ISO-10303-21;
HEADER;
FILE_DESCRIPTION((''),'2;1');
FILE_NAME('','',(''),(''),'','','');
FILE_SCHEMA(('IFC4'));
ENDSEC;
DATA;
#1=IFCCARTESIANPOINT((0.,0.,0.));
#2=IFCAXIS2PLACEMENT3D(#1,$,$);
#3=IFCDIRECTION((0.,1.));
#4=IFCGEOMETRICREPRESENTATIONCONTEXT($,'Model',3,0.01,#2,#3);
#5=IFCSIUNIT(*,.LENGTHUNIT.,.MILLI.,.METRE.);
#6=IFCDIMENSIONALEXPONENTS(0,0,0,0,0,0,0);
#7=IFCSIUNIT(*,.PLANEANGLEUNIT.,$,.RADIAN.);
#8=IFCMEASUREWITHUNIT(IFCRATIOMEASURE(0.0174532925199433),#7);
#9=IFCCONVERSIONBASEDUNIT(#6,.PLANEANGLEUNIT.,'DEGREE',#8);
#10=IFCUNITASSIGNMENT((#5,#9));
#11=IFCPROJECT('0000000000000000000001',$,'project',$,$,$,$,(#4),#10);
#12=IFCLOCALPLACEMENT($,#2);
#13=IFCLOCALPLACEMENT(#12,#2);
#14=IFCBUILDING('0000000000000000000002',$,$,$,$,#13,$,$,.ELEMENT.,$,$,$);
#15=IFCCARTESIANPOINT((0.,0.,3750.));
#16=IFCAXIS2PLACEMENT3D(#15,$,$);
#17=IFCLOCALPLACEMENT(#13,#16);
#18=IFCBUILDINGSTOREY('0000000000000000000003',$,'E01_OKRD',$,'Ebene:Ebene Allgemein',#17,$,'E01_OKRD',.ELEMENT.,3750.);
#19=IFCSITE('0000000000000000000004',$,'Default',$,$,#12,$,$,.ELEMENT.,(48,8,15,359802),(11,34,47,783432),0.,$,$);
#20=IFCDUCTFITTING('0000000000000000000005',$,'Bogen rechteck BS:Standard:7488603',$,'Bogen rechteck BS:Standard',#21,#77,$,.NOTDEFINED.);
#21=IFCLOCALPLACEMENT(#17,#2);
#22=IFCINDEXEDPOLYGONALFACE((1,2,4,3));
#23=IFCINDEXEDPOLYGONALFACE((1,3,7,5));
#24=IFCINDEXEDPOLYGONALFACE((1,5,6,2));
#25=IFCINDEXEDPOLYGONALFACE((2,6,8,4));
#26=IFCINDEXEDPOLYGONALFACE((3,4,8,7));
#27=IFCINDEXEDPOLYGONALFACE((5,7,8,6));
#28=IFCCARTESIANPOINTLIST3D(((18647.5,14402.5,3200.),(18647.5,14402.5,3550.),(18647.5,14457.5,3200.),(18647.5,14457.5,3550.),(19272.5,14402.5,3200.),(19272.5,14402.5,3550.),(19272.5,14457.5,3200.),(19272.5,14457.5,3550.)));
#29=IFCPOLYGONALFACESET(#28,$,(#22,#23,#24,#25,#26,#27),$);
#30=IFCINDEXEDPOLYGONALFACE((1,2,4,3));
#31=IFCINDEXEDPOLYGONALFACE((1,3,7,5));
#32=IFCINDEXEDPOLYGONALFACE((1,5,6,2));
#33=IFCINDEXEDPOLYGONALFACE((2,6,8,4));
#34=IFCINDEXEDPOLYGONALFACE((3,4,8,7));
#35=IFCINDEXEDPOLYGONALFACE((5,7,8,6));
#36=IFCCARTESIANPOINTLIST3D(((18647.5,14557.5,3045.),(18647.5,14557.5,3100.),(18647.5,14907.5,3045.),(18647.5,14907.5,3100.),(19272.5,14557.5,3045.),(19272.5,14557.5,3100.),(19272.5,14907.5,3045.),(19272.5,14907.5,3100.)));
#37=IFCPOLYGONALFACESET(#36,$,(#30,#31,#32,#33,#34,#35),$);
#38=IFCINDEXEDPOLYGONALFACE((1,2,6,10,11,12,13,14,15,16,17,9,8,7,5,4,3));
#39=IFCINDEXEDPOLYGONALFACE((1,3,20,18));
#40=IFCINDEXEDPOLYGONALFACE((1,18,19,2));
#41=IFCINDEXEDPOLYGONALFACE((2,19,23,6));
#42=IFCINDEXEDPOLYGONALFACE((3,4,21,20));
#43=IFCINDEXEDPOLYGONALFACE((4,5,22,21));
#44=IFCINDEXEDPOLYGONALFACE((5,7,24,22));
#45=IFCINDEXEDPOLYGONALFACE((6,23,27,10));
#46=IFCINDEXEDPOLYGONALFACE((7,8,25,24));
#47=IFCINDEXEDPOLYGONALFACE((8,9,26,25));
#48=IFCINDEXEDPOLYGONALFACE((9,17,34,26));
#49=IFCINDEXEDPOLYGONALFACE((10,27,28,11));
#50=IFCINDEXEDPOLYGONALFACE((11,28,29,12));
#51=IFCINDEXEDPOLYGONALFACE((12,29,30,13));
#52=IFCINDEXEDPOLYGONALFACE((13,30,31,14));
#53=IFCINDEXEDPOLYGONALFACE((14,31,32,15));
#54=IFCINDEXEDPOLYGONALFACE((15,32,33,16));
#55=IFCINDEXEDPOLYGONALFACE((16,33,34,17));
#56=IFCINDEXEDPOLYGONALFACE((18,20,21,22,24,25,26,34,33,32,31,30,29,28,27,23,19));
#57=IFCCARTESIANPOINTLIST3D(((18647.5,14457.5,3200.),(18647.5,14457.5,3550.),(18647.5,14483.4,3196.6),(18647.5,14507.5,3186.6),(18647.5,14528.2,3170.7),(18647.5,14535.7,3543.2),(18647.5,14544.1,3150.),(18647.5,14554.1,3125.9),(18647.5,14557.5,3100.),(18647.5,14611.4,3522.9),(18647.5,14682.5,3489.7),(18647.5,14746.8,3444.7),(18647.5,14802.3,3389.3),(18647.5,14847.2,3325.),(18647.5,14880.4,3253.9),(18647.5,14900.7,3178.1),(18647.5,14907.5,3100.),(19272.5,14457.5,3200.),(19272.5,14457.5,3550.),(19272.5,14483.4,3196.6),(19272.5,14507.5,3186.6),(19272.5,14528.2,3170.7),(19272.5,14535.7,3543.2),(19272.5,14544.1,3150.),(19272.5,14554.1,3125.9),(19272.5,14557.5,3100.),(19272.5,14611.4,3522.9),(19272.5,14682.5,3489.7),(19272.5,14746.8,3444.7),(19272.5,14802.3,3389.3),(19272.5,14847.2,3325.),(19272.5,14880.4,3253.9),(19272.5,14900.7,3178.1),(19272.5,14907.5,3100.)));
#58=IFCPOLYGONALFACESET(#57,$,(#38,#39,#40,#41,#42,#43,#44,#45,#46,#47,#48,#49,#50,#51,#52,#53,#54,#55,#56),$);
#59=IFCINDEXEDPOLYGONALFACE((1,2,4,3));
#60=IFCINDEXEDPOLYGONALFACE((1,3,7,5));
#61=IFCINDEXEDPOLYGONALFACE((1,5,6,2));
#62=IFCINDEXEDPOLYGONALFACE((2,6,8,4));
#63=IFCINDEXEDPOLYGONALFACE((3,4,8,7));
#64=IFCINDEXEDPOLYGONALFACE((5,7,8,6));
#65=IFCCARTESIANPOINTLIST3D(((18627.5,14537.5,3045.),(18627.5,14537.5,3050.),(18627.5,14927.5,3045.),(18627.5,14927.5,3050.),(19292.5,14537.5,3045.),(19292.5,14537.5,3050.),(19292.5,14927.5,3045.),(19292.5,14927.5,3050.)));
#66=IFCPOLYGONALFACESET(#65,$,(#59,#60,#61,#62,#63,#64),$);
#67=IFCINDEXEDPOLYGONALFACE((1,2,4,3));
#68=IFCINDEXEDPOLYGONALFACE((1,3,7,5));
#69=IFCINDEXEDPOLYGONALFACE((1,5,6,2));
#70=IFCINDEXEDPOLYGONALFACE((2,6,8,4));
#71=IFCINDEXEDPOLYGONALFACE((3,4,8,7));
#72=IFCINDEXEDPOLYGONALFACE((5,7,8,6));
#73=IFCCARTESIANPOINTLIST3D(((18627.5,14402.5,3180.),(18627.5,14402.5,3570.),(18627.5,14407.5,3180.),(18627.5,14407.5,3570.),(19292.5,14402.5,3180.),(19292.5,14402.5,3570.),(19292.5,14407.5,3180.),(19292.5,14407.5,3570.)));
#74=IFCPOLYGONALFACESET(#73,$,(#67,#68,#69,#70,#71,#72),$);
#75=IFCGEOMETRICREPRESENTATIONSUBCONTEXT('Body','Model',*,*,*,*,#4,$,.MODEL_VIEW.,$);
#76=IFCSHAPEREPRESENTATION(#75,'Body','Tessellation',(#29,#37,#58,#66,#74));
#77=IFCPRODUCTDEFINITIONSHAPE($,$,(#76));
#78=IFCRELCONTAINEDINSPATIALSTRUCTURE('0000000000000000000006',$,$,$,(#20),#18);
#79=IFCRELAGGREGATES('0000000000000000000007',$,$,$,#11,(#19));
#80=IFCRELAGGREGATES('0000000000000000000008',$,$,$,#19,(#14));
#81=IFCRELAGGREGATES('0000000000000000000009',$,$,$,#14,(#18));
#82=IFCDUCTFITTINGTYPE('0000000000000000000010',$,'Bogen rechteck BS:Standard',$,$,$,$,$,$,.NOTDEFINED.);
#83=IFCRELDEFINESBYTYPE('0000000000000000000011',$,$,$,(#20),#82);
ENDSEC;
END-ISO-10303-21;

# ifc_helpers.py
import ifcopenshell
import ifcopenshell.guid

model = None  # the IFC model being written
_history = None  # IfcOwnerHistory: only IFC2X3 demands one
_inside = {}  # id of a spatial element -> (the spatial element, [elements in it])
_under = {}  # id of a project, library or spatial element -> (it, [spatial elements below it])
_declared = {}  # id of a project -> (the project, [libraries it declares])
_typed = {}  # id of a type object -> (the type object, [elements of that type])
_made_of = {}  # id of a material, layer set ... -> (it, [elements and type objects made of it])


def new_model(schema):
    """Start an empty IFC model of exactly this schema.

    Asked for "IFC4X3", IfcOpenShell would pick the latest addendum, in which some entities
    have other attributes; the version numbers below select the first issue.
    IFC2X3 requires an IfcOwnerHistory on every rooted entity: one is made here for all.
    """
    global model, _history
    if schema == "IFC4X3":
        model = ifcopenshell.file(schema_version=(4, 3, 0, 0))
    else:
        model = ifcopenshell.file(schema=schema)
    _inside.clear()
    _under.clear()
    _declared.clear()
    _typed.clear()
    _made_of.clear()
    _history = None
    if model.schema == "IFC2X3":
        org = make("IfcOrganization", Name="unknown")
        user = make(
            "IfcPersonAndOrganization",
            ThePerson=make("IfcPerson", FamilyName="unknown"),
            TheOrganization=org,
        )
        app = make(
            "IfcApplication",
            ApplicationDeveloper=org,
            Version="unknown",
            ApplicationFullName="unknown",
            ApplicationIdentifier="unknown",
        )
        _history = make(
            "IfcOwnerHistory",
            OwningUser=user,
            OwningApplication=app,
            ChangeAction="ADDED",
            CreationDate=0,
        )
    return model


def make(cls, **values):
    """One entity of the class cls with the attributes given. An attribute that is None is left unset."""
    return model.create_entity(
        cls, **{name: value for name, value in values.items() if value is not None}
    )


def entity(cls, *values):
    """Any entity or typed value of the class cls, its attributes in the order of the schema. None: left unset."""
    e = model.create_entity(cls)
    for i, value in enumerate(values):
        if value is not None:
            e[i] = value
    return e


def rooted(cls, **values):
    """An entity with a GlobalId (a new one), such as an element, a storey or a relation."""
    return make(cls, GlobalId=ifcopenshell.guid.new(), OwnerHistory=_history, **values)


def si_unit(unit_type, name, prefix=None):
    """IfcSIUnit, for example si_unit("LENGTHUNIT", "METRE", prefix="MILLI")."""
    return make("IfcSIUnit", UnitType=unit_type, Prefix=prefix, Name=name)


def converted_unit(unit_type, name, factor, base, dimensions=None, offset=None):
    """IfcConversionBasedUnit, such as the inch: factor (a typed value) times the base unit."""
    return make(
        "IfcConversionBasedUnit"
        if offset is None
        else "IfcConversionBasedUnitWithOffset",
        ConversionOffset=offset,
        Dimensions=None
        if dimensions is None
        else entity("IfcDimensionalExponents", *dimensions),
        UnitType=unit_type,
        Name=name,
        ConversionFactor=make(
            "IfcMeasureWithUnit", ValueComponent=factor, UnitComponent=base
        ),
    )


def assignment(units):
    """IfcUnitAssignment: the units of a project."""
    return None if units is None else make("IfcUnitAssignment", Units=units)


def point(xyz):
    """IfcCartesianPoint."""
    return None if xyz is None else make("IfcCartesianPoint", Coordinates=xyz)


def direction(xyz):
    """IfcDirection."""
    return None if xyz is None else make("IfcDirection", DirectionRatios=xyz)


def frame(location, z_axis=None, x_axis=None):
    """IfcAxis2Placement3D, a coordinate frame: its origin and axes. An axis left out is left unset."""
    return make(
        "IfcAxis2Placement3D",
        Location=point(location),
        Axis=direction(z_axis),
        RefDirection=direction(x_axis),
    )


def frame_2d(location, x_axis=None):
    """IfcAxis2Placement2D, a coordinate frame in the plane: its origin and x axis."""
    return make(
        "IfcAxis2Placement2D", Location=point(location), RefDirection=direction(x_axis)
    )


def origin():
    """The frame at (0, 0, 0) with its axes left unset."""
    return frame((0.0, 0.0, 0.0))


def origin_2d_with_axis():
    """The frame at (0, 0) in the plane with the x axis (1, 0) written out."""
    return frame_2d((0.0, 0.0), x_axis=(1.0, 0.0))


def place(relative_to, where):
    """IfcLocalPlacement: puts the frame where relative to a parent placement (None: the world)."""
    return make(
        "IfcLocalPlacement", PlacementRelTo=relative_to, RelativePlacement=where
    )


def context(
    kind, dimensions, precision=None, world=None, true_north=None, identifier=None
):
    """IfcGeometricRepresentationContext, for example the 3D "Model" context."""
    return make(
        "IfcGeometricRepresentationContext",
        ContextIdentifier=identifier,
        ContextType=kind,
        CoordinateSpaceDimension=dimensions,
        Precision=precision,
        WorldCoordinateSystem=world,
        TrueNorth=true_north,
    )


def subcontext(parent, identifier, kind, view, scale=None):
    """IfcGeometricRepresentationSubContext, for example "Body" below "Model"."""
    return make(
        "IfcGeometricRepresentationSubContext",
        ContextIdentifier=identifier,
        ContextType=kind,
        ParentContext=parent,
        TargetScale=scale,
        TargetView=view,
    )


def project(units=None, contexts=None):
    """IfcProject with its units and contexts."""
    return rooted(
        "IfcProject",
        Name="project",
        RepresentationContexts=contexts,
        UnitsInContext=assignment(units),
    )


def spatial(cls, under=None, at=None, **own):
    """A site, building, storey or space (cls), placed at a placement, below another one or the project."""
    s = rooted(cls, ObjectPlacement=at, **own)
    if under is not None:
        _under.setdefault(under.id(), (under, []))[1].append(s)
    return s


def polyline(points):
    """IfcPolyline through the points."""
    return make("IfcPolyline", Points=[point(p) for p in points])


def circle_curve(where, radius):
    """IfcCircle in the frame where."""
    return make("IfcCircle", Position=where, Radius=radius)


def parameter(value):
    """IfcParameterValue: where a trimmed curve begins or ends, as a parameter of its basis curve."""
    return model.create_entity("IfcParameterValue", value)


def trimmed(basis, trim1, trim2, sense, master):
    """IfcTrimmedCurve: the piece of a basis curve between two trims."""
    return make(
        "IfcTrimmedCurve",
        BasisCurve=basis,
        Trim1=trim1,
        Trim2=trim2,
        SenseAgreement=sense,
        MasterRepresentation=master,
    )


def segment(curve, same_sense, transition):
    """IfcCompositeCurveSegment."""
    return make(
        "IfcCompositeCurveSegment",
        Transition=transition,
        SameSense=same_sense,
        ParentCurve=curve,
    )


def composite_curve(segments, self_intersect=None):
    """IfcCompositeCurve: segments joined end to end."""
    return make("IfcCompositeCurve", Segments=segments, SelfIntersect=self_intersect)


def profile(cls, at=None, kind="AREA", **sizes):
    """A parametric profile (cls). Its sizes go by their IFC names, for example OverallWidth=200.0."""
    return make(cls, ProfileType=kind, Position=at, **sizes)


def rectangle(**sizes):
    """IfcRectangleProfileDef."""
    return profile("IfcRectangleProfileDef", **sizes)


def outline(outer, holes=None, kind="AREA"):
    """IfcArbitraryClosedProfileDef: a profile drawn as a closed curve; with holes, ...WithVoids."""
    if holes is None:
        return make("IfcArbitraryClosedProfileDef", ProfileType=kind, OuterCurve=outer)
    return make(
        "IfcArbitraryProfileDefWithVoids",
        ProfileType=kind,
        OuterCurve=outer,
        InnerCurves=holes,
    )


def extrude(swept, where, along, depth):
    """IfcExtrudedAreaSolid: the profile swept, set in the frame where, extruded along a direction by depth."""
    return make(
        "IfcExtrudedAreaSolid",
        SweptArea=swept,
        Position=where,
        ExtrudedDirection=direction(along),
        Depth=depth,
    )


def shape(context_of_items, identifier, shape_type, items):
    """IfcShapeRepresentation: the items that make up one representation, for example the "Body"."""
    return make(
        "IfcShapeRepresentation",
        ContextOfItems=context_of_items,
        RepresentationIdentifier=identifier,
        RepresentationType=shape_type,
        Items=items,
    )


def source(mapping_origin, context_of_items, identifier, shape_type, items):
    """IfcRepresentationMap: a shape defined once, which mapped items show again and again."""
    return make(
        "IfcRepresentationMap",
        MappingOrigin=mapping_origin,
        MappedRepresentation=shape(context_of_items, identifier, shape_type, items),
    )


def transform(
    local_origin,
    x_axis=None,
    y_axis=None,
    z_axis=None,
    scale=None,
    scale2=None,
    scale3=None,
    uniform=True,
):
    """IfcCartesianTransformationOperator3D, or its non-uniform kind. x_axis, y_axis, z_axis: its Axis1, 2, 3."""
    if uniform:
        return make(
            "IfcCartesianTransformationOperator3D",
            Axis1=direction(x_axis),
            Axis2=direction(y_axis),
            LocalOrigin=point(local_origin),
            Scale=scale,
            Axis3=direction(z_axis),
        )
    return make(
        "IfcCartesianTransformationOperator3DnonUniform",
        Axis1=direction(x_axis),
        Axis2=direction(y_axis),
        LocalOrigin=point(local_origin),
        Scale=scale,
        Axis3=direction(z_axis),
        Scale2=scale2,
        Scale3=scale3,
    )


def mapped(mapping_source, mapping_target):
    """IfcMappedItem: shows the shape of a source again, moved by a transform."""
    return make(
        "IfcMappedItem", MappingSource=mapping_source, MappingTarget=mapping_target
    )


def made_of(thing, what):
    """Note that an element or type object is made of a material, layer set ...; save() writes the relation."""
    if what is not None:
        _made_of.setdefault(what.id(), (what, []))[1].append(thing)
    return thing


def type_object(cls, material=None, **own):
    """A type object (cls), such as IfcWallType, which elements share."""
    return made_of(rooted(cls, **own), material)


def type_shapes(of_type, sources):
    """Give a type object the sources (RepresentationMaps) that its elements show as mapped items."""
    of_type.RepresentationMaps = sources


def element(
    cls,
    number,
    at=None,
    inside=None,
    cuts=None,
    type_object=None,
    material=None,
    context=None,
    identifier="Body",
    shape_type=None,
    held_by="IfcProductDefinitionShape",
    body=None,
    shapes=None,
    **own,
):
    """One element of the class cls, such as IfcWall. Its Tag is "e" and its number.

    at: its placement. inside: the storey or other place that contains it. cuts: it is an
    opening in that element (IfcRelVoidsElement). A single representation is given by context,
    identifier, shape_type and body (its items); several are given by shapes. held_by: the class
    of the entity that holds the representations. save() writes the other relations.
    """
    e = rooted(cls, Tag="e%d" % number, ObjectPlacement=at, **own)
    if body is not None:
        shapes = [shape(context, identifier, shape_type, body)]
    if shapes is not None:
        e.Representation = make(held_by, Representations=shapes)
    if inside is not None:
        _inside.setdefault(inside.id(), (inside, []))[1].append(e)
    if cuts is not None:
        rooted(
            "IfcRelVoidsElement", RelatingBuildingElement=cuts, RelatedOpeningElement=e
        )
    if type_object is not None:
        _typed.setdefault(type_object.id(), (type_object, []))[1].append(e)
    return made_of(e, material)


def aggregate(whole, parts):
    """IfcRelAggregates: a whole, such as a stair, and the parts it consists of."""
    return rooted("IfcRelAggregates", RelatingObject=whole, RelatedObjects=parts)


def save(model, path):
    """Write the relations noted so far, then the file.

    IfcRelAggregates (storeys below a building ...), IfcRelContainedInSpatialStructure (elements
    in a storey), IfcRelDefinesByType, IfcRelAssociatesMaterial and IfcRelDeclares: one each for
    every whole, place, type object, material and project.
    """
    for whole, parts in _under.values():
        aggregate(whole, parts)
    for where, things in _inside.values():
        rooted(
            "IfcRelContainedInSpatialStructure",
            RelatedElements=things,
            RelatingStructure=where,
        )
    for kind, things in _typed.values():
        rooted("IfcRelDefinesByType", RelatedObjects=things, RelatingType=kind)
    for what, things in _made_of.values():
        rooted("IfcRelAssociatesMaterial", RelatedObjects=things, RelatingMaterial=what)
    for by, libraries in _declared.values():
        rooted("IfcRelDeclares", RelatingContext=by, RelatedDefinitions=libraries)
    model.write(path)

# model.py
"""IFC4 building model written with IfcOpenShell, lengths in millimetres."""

from ifc_helpers import new_model, entity, si_unit, converted_unit, direction, frame, frame_2d, origin, origin_2d_with_axis, place, context, subcontext, project, spatial, polyline, circle_curve, parameter, trimmed, segment, composite_curve, rectangle, outline, extrude, source, transform, mapped, type_object, type_shapes, element, save


model = new_model("IFC4")

# Units and contexts
model_context = context("Model", 3, precision=0.01, world=origin(), true_north=direction((0.0, 1.0)))
body_context = subcontext(model_context, "Body", "Model", "MODEL_VIEW")
ifc_project = project(units=[si_unit("LENGTHUNIT", "METRE", prefix="MILLI"), converted_unit("PLANEANGLEUNIT", "DEGREE", entity("IfcRatioMeasure", 0.0174532925199433), si_unit("PLANEANGLEUNIT", "RADIAN"), dimensions=[0, 0, 0, 0, 0, 0, 0])], contexts=[model_context])

# Site, building, storey
site_placement = place(None, origin())
site = spatial("IfcSite", under=ifc_project, at=site_placement, Name="Default", CompositionType="ELEMENT", RefLatitude=(48, 8, 15, 359802), RefLongitude=(11, 34, 47, 783432), RefElevation=0.0)
building_placement = place(site_placement, origin())
building = spatial("IfcBuilding", under=site, at=building_placement, CompositionType="ELEMENT")
storey_placement = place(building_placement, frame((0.0, 0.0, 3750.0)))
storey = spatial("IfcBuildingStorey", under=building, at=storey_placement, Name="E01_OKRD", ObjectType="Ebene:Ebene Allgemein", LongName="E01_OKRD", CompositionType="ELEMENT", Elevation=3750.0)

# Duct fitting
duct_fitting_type_1 = type_object("IfcDuctFittingType", Name="Bogen rechteck BS:Standard", PredefinedType="NOTDEFINED")
shared_shape_1 = source(origin(), body_context, "Body", "SweptSolid", [
    extrude(rectangle(XDim=55.0, YDim=350.0, at=origin_2d_with_axis()), frame((0.0, 302.5, -312.5), z_axis=(0.0, 0.0, 1.0), x_axis=(0.0, 1.0, 0.0)), (0.0, 0.0, 1.0), 625.0),
    extrude(rectangle(XDim=350.0, YDim=55.0, at=frame_2d((0.0, 0.0), x_axis=(1.0, 0.0))), frame((-302.5, 0.0, -312.5), z_axis=(0.0, 0.0, 1.0), x_axis=(0.0, -1.0, 0.0)), (0.0, 0.0, 1.0), 625.0),
    extrude(outline(composite_curve([segment(polyline([(-312.5, -137.5), (37.5, -137.5)]), True, "CONTINUOUS"), segment(trimmed(circle_curve(frame_2d((137.5, -137.5), x_axis=(0.0, 1.0)), 100.0), [parameter(0.0)], [parameter(90.0)], True, "PARAMETER"), False, "CONTINUOUS"), segment(polyline([(137.5, -37.5), (137.5, 312.5)]), True, "CONTINUOUS"), segment(trimmed(circle_curve(frame_2d((137.5, -137.5), x_axis=(0.0, 1.0)), 450.0), [parameter(0.0)], [parameter(90.0)], True, "PARAMETER"), True, "CONTINUOUS")], self_intersect=False)), frame((-137.5, 137.5, -312.5), z_axis=(0.0, 0.0, 1.0), x_axis=(-1.0, 0.0, 0.0)), (0.0, 0.0, 1.0), 625.0),
    extrude(rectangle(XDim=5.0, YDim=390.0, at=frame_2d((0.0, 0.0), x_axis=(1.0, 0.0))), frame((-327.5, 0.0, -332.5)), (0.0, 0.0, 1.0), 665.0),
    extrude(rectangle(XDim=5.0, YDim=390.0, at=frame_2d((0.0, 0.0), x_axis=(1.0, 0.0))), frame((0.0, 327.5, -332.5), z_axis=(0.0, 0.0, 1.0), x_axis=(0.0, 1.0, 0.0)), (0.0, 0.0, 1.0), 665.0),
])
type_shapes(duct_fitting_type_1, [shared_shape_1])
duct_fitting_1_placement = place(storey_placement, frame((18960.0, 14732.5, 3375.0), z_axis=(1.0, 0.0, 0.0), x_axis=(0.0, 0.0, 1.0)))
element("IfcDuctFitting", 1, at=duct_fitting_1_placement, inside=storey, type_object=duct_fitting_type_1, Name="Bogen rechteck BS:Standard:7488603", ObjectType="Bogen rechteck BS:Standard", PredefinedType="NOTDEFINED", context=body_context, shape_type="MappedRepresentation", body=[
    mapped(shared_shape_1, transform((0.0, 0.0, 0.0), scale=1.0)),
])

save(model, "model.ifc")
